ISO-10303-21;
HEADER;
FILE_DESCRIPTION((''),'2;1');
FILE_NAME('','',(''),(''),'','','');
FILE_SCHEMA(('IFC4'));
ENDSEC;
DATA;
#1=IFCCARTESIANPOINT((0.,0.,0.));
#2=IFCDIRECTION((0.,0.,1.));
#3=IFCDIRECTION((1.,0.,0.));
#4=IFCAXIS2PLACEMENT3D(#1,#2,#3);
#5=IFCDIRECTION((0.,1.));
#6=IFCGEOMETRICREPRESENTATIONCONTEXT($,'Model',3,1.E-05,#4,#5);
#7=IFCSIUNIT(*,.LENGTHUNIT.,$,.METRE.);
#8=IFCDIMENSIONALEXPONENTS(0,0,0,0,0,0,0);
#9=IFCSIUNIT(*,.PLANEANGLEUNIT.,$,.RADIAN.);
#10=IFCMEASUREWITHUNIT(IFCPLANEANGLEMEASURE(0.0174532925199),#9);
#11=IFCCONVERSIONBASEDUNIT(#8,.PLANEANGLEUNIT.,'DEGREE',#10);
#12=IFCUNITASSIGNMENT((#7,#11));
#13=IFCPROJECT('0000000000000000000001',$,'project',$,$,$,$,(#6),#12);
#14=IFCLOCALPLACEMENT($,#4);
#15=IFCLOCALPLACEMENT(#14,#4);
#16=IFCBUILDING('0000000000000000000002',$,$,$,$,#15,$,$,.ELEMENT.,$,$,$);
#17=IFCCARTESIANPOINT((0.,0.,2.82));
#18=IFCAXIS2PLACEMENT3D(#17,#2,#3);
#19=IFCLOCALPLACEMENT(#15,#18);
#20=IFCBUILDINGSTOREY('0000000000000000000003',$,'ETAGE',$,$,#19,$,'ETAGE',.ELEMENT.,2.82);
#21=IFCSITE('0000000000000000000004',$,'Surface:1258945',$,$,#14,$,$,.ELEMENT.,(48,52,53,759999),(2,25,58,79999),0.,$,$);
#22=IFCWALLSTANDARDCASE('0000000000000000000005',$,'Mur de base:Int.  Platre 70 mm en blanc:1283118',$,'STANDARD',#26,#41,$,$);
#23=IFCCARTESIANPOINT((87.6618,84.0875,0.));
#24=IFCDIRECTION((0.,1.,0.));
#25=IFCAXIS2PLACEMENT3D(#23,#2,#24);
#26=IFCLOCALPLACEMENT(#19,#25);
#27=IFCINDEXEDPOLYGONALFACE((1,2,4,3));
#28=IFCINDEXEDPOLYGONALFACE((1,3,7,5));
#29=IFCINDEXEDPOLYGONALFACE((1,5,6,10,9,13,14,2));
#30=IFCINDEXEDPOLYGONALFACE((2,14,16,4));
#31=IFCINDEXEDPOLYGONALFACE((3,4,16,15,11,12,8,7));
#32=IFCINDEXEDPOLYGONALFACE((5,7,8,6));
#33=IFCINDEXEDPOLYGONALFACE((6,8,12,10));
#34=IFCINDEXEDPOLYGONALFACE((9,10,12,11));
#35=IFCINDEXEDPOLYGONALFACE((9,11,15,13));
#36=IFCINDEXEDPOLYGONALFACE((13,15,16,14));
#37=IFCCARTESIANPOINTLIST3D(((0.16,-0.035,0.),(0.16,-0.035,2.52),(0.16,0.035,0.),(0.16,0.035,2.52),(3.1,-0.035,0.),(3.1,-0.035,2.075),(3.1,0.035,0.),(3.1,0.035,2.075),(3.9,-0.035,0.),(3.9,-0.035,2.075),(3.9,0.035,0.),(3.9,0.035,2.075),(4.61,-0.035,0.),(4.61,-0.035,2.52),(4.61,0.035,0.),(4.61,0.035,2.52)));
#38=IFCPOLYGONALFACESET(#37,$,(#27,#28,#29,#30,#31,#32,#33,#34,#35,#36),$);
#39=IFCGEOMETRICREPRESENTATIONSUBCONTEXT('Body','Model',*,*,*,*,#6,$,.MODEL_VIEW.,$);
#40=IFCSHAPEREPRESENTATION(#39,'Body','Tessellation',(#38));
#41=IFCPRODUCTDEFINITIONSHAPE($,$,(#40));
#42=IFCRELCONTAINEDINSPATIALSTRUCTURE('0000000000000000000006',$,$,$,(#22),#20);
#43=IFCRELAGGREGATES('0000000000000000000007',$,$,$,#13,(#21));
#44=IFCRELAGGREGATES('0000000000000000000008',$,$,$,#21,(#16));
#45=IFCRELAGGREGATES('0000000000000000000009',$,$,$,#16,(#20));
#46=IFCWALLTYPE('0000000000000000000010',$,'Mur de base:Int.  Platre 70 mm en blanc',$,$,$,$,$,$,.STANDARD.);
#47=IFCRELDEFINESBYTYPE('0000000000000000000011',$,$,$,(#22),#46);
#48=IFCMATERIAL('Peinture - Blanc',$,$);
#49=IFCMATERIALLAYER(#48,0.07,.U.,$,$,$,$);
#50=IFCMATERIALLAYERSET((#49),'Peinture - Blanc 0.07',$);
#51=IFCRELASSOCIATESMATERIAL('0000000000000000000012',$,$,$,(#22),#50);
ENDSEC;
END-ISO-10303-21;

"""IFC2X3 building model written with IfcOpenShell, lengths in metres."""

from ifc_helpers import new_model, entity, si_unit, converted_unit, direction, frame, origin_with_axes, place, context, subcontext, project, spatial, polyline, outline, extrude, material, layer, layer_set, layer_usage, type_object, element, save


model = new_model("IFC2X3")

# Units and contexts
model_context = context("Model", 3, precision=1e-05, world=origin_with_axes(), true_north=direction((0.0, 1.0)))
body_context = subcontext(model_context, "Body", "Model", "MODEL_VIEW")
ifc_project = project(units=[si_unit("LENGTHUNIT", "METRE"), converted_unit("PLANEANGLEUNIT", "DEGREE", entity("IfcPlaneAngleMeasure", 0.0174532925199), si_unit("PLANEANGLEUNIT", "RADIAN"), dimensions=[0, 0, 0, 0, 0, 0, 0])], contexts=[model_context])

# Site, building, storey
site_placement = place(None, origin_with_axes())
site = spatial("IfcSite", under=ifc_project, at=site_placement, Name="Surface:1258945", CompositionType="ELEMENT", RefLatitude=(48, 52, 53, 759999), RefLongitude=(2, 25, 58, 79999), RefElevation=0.0)
building_placement = place(site_placement, origin_with_axes())
building = spatial("IfcBuilding", under=site, at=building_placement, CompositionType="ELEMENT")
storey_placement = place(building_placement, frame((0.0, 0.0, 2.82), z_axis=(0.0, 0.0, 1.0), x_axis=(1.0, 0.0, 0.0)))
storey = spatial("IfcBuildingStorey", under=building, at=storey_placement, Name="ETAGE", LongName="ETAGE", CompositionType="ELEMENT", Elevation=2.82)

# Wall, opening
ifc_material_1 = material(Name="Peinture - Blanc")
ifc_layer_1 = layer(ifc_material_1, 0.07, ventilated="UNKNOWN")
ifc_layer_set_1 = layer_set([ifc_layer_1], Name="Peinture - Blanc 0.07")
ifc_layer_usage_1 = layer_usage(ifc_layer_set_1, "AXIS2", "POSITIVE", -0.035)
wall_type_1 = type_object("IfcWallType", Name="Mur de base:Int.  Platre 70 mm en blanc", PredefinedType="STANDARD")
wall_1_placement = place(storey_placement, frame((87.6618, 84.0875, 0.0), z_axis=(0.0, 0.0, 1.0), x_axis=(0.0, 1.0, 0.0)))
wall_1 = element("IfcWallStandardCase", 1, at=wall_1_placement, inside=storey, type_object=wall_type_1, material=ifc_layer_usage_1, Name="Mur de base:Int.  Platre 70 mm en blanc:1283118", ObjectType="STANDARD", context=body_context, shape_type="SweptSolid", body=[
    extrude(outline(polyline([(0.16, -0.035), (4.61, -0.035), (4.61, 0.035), (0.16, 0.035), (0.16, -0.035)])), origin_with_axes(), (0.0, 0.0, 1.0), 2.52),
])
opening_placement = place(wall_1_placement, frame((3.5, 0.0, 0.0), z_axis=(0.0, 0.0, 1.0), x_axis=(1.0, 0.0, 0.0)))
element("IfcOpeningElement", 2, at=opening_placement, cuts=wall_1, context=body_context, shape_type="SweptSolid", body=[
    extrude(outline(polyline([(-0.4, 0.0), (0.4, 0.0), (0.4, 2.075), (-0.4, 2.075), (-0.4, 0.0)])), frame((0.0, 0.035, 0.0), z_axis=(0.0, 1.0, 0.0), x_axis=(-1.0, 0.0, 0.0)), (0.0, 0.0, -1.0), 0.07),
])

save(model, "model.ifc")
